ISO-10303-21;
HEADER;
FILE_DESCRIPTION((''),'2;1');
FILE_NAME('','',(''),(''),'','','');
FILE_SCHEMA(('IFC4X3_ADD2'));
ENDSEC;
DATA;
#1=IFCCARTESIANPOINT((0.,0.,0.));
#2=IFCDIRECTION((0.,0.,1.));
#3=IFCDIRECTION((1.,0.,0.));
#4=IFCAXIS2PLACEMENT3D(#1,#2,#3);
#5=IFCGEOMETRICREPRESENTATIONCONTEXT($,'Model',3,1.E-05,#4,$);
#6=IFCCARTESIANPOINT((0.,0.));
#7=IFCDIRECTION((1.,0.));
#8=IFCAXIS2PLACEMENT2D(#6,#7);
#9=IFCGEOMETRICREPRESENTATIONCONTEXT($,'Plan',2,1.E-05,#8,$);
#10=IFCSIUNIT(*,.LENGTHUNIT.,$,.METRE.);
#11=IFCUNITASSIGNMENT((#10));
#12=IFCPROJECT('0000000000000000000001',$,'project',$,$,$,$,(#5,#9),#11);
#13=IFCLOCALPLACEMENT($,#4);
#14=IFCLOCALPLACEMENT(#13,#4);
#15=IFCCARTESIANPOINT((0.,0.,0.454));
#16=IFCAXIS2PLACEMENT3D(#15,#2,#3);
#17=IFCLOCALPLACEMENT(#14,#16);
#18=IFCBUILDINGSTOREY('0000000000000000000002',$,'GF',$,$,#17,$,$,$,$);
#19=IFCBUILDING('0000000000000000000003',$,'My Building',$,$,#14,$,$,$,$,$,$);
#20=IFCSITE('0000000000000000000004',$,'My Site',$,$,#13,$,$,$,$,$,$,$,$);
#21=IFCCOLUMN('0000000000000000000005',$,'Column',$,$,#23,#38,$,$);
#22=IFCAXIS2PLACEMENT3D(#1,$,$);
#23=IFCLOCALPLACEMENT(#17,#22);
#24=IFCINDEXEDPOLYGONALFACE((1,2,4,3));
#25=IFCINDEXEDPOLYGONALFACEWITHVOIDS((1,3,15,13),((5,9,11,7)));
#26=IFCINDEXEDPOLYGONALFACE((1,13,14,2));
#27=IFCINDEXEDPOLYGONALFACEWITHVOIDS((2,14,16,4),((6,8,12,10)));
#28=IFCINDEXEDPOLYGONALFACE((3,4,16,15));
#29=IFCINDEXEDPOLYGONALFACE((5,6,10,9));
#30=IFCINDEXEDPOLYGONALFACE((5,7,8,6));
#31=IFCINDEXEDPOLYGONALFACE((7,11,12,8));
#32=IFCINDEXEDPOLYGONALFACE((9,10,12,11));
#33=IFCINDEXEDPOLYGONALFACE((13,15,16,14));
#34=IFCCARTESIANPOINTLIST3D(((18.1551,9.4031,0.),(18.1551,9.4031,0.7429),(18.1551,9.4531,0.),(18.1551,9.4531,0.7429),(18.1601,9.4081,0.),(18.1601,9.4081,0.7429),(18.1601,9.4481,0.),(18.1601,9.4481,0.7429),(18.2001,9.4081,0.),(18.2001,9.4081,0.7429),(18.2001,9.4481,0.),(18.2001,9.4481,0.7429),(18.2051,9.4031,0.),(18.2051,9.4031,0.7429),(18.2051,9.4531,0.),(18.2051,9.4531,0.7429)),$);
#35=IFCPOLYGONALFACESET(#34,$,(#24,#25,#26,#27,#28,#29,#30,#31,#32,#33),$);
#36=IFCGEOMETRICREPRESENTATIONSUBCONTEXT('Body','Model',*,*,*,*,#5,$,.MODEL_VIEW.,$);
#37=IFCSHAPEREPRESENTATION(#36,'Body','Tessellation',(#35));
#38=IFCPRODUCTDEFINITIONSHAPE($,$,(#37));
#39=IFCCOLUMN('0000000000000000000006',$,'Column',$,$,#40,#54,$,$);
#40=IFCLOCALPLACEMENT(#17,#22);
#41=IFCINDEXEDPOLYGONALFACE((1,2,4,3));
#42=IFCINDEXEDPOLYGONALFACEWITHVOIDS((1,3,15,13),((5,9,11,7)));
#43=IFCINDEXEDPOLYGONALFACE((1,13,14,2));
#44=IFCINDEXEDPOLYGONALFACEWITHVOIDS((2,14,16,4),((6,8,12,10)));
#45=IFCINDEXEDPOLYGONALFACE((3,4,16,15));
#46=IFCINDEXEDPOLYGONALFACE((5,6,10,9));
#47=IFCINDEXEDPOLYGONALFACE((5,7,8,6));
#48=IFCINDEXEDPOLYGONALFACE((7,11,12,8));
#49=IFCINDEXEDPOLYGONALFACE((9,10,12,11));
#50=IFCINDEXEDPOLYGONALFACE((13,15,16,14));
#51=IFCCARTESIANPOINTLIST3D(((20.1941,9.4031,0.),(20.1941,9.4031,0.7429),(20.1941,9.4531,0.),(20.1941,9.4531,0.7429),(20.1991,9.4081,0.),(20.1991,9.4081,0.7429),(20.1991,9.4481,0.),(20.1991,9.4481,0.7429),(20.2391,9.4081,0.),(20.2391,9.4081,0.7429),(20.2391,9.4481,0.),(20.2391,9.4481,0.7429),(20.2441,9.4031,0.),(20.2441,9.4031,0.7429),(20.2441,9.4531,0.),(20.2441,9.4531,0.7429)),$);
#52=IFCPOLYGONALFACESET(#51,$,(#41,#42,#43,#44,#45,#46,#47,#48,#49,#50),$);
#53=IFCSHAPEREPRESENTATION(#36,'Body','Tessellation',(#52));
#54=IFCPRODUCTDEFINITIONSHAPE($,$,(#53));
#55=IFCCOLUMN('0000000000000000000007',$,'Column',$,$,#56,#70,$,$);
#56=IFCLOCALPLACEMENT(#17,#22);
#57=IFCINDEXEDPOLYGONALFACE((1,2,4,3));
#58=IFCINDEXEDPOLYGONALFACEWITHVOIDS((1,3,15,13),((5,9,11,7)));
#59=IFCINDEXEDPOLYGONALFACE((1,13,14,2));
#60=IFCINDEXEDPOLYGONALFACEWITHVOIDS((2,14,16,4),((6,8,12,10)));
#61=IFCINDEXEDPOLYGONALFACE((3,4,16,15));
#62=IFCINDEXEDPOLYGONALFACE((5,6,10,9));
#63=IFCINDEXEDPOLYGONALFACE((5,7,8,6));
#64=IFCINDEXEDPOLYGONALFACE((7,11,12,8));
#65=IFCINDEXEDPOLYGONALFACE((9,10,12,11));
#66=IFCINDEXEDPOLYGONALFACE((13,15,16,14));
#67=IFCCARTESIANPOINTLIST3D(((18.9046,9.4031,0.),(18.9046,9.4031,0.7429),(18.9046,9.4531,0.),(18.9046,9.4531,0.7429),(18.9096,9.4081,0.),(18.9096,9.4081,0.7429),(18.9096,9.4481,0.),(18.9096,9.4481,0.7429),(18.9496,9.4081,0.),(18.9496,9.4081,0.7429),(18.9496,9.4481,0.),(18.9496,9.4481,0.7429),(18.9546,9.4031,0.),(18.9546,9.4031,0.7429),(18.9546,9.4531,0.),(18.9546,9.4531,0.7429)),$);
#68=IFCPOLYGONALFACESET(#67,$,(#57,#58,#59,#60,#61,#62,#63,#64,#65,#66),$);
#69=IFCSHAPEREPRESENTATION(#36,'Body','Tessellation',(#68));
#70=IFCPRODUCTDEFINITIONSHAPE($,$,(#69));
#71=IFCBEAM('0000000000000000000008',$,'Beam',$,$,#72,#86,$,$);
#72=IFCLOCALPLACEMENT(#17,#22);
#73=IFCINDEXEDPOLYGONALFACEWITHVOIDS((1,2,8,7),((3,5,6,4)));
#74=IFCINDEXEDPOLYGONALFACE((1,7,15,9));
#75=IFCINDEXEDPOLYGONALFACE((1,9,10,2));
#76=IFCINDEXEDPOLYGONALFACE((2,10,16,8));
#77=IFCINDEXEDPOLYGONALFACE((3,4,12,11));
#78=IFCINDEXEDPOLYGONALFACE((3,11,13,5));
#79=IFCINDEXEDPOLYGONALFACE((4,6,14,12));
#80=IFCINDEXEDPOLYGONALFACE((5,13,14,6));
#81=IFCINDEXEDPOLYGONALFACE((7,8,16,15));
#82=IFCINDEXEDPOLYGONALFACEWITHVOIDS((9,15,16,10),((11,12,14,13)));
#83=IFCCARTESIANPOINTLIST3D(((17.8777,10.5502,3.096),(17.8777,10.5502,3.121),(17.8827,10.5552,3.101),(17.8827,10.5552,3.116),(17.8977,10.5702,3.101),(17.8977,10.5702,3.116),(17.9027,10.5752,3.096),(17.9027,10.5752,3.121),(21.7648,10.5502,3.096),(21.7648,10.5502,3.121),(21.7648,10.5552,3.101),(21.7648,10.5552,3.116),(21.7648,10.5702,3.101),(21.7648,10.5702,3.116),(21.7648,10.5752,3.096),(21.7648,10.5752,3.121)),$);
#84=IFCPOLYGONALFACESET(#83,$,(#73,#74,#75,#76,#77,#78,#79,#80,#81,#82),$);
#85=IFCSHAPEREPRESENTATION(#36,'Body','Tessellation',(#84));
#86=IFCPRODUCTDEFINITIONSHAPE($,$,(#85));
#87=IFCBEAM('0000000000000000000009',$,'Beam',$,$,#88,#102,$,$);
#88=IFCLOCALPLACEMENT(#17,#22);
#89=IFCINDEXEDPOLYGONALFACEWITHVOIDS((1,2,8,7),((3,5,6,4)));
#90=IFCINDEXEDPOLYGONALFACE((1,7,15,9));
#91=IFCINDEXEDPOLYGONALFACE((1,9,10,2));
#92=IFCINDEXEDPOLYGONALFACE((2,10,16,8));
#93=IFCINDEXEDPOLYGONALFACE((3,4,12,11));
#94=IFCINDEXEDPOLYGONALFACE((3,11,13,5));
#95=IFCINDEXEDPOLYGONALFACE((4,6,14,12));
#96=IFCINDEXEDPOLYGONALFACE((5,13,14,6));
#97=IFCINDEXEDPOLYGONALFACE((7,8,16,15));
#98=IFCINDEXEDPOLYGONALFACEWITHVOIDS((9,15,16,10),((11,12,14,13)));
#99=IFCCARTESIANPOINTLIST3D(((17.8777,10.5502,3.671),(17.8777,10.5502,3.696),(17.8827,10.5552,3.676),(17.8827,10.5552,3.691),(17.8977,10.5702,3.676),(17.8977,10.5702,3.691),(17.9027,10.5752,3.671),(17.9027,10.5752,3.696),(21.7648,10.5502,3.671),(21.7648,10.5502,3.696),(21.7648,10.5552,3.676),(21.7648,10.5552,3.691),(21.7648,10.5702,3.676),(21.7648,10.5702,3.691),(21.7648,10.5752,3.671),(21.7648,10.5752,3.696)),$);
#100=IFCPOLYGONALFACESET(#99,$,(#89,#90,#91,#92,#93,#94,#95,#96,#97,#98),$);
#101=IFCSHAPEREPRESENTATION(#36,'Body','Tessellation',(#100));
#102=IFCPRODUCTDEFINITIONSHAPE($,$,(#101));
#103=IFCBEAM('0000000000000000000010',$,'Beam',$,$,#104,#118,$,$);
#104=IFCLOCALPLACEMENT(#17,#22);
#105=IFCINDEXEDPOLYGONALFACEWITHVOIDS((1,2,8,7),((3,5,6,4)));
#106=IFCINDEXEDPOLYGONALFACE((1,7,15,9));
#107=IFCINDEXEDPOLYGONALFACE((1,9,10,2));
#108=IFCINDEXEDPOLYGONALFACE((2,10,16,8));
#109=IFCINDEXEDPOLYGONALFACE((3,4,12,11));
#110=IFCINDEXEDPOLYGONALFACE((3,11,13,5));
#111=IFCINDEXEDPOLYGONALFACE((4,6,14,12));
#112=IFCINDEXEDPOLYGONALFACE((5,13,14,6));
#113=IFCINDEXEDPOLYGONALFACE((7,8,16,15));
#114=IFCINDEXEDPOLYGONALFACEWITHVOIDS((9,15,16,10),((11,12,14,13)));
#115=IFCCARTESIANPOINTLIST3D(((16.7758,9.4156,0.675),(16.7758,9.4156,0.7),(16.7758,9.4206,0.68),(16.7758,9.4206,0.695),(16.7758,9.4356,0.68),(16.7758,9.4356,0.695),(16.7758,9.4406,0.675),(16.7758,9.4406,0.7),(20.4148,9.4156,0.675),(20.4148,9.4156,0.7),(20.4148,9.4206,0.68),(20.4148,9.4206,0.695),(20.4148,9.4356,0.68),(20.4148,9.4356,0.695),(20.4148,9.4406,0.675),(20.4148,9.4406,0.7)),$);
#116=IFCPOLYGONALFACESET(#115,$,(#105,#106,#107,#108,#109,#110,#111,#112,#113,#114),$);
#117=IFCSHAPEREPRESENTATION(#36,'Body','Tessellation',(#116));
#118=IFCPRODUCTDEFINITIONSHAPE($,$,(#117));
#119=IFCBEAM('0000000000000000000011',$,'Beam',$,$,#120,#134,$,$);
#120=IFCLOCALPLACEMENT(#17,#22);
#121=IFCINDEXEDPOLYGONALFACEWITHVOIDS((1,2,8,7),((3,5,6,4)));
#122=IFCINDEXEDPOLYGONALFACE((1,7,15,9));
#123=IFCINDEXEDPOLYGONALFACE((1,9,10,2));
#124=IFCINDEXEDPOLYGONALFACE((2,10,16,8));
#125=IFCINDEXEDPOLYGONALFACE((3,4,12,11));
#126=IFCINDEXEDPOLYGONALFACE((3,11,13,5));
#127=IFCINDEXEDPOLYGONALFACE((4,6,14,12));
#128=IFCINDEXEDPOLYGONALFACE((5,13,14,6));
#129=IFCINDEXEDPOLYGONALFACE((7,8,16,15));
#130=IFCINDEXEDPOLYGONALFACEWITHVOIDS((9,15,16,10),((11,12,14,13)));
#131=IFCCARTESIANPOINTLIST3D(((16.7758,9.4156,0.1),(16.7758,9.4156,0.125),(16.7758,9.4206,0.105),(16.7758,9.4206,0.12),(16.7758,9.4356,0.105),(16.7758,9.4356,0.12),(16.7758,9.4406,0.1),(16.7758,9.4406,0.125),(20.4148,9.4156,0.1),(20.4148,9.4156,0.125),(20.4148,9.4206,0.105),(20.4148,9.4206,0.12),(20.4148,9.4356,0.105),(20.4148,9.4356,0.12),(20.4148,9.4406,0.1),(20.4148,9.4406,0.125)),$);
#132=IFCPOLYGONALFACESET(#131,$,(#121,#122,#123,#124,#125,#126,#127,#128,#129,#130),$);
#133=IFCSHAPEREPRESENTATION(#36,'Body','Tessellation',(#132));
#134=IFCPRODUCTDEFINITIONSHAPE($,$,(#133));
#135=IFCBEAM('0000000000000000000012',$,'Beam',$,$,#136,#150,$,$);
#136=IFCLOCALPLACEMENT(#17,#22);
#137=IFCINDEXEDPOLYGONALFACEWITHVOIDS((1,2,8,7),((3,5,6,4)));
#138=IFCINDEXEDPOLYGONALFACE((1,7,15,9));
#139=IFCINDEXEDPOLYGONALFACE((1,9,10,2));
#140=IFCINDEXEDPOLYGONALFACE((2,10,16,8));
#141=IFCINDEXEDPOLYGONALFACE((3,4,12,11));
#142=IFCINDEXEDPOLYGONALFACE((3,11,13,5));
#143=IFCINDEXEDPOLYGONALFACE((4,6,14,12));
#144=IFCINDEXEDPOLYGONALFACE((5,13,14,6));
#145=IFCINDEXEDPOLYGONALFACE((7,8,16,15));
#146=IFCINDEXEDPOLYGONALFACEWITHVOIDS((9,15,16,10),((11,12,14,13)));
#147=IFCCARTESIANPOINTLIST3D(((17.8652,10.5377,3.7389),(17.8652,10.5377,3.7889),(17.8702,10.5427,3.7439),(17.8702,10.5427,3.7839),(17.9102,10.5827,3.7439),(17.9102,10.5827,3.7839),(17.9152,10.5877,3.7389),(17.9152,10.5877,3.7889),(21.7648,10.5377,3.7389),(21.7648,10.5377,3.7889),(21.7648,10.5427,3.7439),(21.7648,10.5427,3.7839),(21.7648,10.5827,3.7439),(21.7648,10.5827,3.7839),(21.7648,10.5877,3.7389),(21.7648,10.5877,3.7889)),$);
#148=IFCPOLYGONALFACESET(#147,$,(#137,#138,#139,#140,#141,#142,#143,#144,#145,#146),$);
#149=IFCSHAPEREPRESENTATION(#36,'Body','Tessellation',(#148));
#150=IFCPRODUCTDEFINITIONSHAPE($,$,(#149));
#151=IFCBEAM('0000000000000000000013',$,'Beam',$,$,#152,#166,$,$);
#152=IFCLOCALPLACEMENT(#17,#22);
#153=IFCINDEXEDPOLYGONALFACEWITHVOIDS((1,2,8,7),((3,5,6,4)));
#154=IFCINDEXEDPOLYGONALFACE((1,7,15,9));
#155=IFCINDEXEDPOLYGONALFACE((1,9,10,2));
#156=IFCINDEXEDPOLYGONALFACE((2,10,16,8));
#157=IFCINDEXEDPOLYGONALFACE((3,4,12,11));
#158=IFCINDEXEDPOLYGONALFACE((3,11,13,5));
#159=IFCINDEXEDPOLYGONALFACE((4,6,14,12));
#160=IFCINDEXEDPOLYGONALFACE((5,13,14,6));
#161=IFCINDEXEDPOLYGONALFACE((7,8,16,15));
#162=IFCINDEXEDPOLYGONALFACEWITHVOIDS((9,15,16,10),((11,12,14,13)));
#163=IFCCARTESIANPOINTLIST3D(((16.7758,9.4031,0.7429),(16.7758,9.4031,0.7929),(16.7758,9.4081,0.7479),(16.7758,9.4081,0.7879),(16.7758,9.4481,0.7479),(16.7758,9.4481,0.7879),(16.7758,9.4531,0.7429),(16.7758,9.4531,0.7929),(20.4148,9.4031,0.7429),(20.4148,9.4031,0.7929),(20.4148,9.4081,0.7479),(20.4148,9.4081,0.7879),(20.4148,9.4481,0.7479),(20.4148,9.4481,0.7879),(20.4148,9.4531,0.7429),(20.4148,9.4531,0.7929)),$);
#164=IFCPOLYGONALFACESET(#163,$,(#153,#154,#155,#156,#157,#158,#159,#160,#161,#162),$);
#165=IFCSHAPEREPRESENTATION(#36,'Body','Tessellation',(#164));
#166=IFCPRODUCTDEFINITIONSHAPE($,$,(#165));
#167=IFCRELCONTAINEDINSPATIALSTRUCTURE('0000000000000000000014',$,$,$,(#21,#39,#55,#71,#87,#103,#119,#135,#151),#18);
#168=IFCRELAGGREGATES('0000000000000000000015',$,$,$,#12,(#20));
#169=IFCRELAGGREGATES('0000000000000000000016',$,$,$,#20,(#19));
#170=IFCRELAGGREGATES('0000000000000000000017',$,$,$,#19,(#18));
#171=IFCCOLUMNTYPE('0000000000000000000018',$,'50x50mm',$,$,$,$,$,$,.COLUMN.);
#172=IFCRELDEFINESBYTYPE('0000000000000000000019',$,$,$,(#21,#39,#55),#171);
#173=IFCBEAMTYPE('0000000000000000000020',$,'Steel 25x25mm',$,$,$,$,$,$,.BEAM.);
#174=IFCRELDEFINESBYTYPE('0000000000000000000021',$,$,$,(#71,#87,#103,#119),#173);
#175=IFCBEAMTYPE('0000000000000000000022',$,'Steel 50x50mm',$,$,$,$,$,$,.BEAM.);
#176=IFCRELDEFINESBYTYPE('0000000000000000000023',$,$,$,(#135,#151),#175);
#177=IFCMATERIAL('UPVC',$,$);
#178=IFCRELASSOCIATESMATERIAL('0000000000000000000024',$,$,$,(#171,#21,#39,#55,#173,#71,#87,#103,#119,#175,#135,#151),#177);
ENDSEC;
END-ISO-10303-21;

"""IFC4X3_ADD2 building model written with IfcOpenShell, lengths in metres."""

from ifc_helpers import new_model, si_unit, frame, origin_with_axes, origin_2d_with_axis, place, context, subcontext, project, spatial, hollow_rectangle, extrude, clip, halfspace, material, material_profile, profile_set, profile_usage, type_object, element, save


model = new_model("IFC4X3_ADD2")

# Units and contexts
model_context = context("Model", 3, precision=1e-05, world=origin_with_axes())
plan_context = context("Plan", 2, precision=1e-05, world=origin_2d_with_axis())
body_context = subcontext(model_context, "Body", "Model", "MODEL_VIEW")
ifc_project = project(units=[si_unit("LENGTHUNIT", "METRE")], contexts=[model_context, plan_context])

# Site, building, storey
site_placement = place(None, origin_with_axes())
site = spatial("IfcSite", under=ifc_project, at=site_placement, Name="My Site")
building_placement = place(site_placement, origin_with_axes())
building = spatial("IfcBuilding", under=site, at=building_placement, Name="My Building")
storey_placement = place(building_placement, frame((0.0, 0.0, 0.454), z_axis=(0.0, 0.0, 1.0), x_axis=(1.0, 0.0, 0.0)))
storey = spatial("IfcBuildingStorey", under=building, at=storey_placement, Name="GF")

# Columns
ifc_material = material(Name="UPVC")
ifc_material_profile_1 = material_profile(ifc_material, hollow_rectangle(XDim=0.05, YDim=0.05, WallThickness=0.005))
ifc_profile_set_1 = profile_set([ifc_material_profile_1])
column_type_1 = type_object("IfcColumnType", Name="50x50mm", PredefinedType="COLUMN", material=ifc_profile_set_1)
ifc_profile_usage_1 = profile_usage(ifc_profile_set_1)
column_1_placement = place(storey_placement, frame((18.1801, 9.4281, 0.0), z_axis=(0.0, 0.0, 1.0), x_axis=(1.0, 0.0, 0.0)))
element("IfcColumn", 1, at=column_1_placement, inside=storey, type_object=column_type_1, material=ifc_profile_usage_1, Name="Column", context=body_context, shape_type="SweptSolid", body=[
    extrude(hollow_rectangle(XDim=0.05, YDim=0.05, WallThickness=0.005), origin_with_axes(), (0.0, 0.0, 1.0), 0.7429),
])
ifc_profile_usage_2 = profile_usage(ifc_profile_set_1)
column_2_placement = place(storey_placement, frame((20.2191, 9.4281, 0.0), z_axis=(0.0, 0.0, 1.0), x_axis=(1.0, 0.0, 0.0)))
element("IfcColumn", 2, at=column_2_placement, inside=storey, type_object=column_type_1, material=ifc_profile_usage_2, Name="Column", context=body_context, shape_type="SweptSolid", body=[
    extrude(hollow_rectangle(XDim=0.05, YDim=0.05, WallThickness=0.005), origin_with_axes(), (0.0, 0.0, 1.0), 0.7429),
])
ifc_profile_usage_3 = profile_usage(ifc_profile_set_1)
column_3_placement = place(storey_placement, frame((18.9296, 9.4281, 0.0), z_axis=(0.0, 0.0, 1.0), x_axis=(1.0, 0.0, 0.0)))
element("IfcColumn", 3, at=column_3_placement, inside=storey, type_object=column_type_1, material=ifc_profile_usage_3, Name="Column", context=body_context, shape_type="SweptSolid", body=[
    extrude(hollow_rectangle(XDim=0.05, YDim=0.05, WallThickness=0.005), origin_with_axes(), (0.0, 0.0, 1.0), 0.7429),
])

# Beams
ifc_material_profile_2 = material_profile(ifc_material, hollow_rectangle(XDim=0.025, YDim=0.025, WallThickness=0.005))
ifc_profile_set_2 = profile_set([ifc_material_profile_2])
ifc_profile_usage_4 = profile_usage(ifc_profile_set_2)
beam_type_1 = type_object("IfcBeamType", Name="Steel 25x25mm", PredefinedType="BEAM", material=ifc_profile_set_2)
beam_1_placement = place(storey_placement, frame((17.8777, 10.5627, 3.1085), z_axis=(1.0, 0.0, 0.0), x_axis=(0.0, 1.0, 0.0)))
element("IfcBeam", 4, at=beam_1_placement, inside=storey, type_object=beam_type_1, material=ifc_profile_usage_4, Name="Beam", context=body_context, shape_type="Clipping", body=[
    clip(extrude(hollow_rectangle(XDim=0.025, YDim=0.025, WallThickness=0.005), origin_with_axes(), (0.0, 0.0, 1.0), 3.8871), halfspace(frame((-0.0125, -3.5625, 0.0), z_axis=(0.707134, 0.0, -0.70708), x_axis=(0.0, -1.0, 0.0)), False)),
])
ifc_profile_usage_5 = profile_usage(ifc_profile_set_2)
beam_2_placement = place(storey_placement, frame((17.8777, 10.5627, 3.6835), z_axis=(1.0, 0.0, 0.0), x_axis=(0.0, 1.0, 0.0)))
element("IfcBeam", 5, at=beam_2_placement, inside=storey, type_object=beam_type_1, material=ifc_profile_usage_5, Name="Beam", context=body_context, shape_type="Clipping", body=[
    clip(extrude(hollow_rectangle(XDim=0.025, YDim=0.025, WallThickness=0.005), origin_with_axes(), (0.0, 0.0, 1.0), 3.8871), halfspace(frame((-0.0125, -4.1375, 0.0), z_axis=(0.707134, 0.0, -0.70708), x_axis=(0.0, -1.0, 0.0)), False)),
])
ifc_profile_usage_6 = profile_usage(ifc_profile_set_2)
beam_3_placement = place(storey_placement, frame((16.7758, 9.4281, 0.6875), z_axis=(1.0, 0.0, 0.0), x_axis=(0.0, 1.0, 0.0)))
element("IfcBeam", 6, at=beam_3_placement, inside=storey, type_object=beam_type_1, material=ifc_profile_usage_6, Name="Beam", context=body_context, shape_type="SweptSolid", body=[
    extrude(hollow_rectangle(XDim=0.025, YDim=0.025, WallThickness=0.005), origin_with_axes(), (0.0, 0.0, 1.0), 3.6389),
])
ifc_profile_usage_7 = profile_usage(ifc_profile_set_2)
beam_4_placement = place(storey_placement, frame((16.7758, 9.4281, 0.1125), z_axis=(1.0, 0.0, 0.0), x_axis=(0.0, 1.0, 0.0)))
element("IfcBeam", 7, at=beam_4_placement, inside=storey, type_object=beam_type_1, material=ifc_profile_usage_7, Name="Beam", context=body_context, shape_type="SweptSolid", body=[
    extrude(hollow_rectangle(XDim=0.025, YDim=0.025, WallThickness=0.005), origin_with_axes(), (0.0, 0.0, 1.0), 3.6389),
])
ifc_material_profile_3 = material_profile(ifc_material, hollow_rectangle(XDim=0.05, YDim=0.05, WallThickness=0.005))
ifc_profile_set_3 = profile_set([ifc_material_profile_3])
ifc_profile_usage_8 = profile_usage(ifc_profile_set_3)
beam_type_2 = type_object("IfcBeamType", Name="Steel 50x50mm", PredefinedType="BEAM", material=ifc_profile_set_3)
beam_5_placement = place(storey_placement, frame((17.8652, 10.5627, 3.7639), z_axis=(1.0, 0.0, 0.0), x_axis=(0.0, 1.0, 0.0)))
element("IfcBeam", 8, at=beam_5_placement, inside=storey, type_object=beam_type_2, material=ifc_profile_usage_8, Name="Beam", context=body_context, shape_type="Clipping", body=[
    clip(extrude(hollow_rectangle(XDim=0.05, YDim=0.05, WallThickness=0.005), origin_with_axes(), (0.0, 0.0, 1.0), 3.8996), halfspace(frame((-0.025, -4.2179, 0.0), z_axis=(0.707107, 0.0, -0.707107), x_axis=(0.0, -1.0, 0.0)), False)),
])
ifc_profile_usage_9 = profile_usage(ifc_profile_set_3)
beam_6_placement = place(storey_placement, frame((16.7758, 9.4281, 0.7679), z_axis=(1.0, 0.0, 0.0), x_axis=(0.0, 1.0, 0.0)))
element("IfcBeam", 9, at=beam_6_placement, inside=storey, type_object=beam_type_2, material=ifc_profile_usage_9, Name="Beam", context=body_context, shape_type="SweptSolid", body=[
    extrude(hollow_rectangle(XDim=0.05, YDim=0.05, WallThickness=0.005), origin_with_axes(), (0.0, 0.0, 1.0), 3.6389),
])

save(model, "model.ifc")
